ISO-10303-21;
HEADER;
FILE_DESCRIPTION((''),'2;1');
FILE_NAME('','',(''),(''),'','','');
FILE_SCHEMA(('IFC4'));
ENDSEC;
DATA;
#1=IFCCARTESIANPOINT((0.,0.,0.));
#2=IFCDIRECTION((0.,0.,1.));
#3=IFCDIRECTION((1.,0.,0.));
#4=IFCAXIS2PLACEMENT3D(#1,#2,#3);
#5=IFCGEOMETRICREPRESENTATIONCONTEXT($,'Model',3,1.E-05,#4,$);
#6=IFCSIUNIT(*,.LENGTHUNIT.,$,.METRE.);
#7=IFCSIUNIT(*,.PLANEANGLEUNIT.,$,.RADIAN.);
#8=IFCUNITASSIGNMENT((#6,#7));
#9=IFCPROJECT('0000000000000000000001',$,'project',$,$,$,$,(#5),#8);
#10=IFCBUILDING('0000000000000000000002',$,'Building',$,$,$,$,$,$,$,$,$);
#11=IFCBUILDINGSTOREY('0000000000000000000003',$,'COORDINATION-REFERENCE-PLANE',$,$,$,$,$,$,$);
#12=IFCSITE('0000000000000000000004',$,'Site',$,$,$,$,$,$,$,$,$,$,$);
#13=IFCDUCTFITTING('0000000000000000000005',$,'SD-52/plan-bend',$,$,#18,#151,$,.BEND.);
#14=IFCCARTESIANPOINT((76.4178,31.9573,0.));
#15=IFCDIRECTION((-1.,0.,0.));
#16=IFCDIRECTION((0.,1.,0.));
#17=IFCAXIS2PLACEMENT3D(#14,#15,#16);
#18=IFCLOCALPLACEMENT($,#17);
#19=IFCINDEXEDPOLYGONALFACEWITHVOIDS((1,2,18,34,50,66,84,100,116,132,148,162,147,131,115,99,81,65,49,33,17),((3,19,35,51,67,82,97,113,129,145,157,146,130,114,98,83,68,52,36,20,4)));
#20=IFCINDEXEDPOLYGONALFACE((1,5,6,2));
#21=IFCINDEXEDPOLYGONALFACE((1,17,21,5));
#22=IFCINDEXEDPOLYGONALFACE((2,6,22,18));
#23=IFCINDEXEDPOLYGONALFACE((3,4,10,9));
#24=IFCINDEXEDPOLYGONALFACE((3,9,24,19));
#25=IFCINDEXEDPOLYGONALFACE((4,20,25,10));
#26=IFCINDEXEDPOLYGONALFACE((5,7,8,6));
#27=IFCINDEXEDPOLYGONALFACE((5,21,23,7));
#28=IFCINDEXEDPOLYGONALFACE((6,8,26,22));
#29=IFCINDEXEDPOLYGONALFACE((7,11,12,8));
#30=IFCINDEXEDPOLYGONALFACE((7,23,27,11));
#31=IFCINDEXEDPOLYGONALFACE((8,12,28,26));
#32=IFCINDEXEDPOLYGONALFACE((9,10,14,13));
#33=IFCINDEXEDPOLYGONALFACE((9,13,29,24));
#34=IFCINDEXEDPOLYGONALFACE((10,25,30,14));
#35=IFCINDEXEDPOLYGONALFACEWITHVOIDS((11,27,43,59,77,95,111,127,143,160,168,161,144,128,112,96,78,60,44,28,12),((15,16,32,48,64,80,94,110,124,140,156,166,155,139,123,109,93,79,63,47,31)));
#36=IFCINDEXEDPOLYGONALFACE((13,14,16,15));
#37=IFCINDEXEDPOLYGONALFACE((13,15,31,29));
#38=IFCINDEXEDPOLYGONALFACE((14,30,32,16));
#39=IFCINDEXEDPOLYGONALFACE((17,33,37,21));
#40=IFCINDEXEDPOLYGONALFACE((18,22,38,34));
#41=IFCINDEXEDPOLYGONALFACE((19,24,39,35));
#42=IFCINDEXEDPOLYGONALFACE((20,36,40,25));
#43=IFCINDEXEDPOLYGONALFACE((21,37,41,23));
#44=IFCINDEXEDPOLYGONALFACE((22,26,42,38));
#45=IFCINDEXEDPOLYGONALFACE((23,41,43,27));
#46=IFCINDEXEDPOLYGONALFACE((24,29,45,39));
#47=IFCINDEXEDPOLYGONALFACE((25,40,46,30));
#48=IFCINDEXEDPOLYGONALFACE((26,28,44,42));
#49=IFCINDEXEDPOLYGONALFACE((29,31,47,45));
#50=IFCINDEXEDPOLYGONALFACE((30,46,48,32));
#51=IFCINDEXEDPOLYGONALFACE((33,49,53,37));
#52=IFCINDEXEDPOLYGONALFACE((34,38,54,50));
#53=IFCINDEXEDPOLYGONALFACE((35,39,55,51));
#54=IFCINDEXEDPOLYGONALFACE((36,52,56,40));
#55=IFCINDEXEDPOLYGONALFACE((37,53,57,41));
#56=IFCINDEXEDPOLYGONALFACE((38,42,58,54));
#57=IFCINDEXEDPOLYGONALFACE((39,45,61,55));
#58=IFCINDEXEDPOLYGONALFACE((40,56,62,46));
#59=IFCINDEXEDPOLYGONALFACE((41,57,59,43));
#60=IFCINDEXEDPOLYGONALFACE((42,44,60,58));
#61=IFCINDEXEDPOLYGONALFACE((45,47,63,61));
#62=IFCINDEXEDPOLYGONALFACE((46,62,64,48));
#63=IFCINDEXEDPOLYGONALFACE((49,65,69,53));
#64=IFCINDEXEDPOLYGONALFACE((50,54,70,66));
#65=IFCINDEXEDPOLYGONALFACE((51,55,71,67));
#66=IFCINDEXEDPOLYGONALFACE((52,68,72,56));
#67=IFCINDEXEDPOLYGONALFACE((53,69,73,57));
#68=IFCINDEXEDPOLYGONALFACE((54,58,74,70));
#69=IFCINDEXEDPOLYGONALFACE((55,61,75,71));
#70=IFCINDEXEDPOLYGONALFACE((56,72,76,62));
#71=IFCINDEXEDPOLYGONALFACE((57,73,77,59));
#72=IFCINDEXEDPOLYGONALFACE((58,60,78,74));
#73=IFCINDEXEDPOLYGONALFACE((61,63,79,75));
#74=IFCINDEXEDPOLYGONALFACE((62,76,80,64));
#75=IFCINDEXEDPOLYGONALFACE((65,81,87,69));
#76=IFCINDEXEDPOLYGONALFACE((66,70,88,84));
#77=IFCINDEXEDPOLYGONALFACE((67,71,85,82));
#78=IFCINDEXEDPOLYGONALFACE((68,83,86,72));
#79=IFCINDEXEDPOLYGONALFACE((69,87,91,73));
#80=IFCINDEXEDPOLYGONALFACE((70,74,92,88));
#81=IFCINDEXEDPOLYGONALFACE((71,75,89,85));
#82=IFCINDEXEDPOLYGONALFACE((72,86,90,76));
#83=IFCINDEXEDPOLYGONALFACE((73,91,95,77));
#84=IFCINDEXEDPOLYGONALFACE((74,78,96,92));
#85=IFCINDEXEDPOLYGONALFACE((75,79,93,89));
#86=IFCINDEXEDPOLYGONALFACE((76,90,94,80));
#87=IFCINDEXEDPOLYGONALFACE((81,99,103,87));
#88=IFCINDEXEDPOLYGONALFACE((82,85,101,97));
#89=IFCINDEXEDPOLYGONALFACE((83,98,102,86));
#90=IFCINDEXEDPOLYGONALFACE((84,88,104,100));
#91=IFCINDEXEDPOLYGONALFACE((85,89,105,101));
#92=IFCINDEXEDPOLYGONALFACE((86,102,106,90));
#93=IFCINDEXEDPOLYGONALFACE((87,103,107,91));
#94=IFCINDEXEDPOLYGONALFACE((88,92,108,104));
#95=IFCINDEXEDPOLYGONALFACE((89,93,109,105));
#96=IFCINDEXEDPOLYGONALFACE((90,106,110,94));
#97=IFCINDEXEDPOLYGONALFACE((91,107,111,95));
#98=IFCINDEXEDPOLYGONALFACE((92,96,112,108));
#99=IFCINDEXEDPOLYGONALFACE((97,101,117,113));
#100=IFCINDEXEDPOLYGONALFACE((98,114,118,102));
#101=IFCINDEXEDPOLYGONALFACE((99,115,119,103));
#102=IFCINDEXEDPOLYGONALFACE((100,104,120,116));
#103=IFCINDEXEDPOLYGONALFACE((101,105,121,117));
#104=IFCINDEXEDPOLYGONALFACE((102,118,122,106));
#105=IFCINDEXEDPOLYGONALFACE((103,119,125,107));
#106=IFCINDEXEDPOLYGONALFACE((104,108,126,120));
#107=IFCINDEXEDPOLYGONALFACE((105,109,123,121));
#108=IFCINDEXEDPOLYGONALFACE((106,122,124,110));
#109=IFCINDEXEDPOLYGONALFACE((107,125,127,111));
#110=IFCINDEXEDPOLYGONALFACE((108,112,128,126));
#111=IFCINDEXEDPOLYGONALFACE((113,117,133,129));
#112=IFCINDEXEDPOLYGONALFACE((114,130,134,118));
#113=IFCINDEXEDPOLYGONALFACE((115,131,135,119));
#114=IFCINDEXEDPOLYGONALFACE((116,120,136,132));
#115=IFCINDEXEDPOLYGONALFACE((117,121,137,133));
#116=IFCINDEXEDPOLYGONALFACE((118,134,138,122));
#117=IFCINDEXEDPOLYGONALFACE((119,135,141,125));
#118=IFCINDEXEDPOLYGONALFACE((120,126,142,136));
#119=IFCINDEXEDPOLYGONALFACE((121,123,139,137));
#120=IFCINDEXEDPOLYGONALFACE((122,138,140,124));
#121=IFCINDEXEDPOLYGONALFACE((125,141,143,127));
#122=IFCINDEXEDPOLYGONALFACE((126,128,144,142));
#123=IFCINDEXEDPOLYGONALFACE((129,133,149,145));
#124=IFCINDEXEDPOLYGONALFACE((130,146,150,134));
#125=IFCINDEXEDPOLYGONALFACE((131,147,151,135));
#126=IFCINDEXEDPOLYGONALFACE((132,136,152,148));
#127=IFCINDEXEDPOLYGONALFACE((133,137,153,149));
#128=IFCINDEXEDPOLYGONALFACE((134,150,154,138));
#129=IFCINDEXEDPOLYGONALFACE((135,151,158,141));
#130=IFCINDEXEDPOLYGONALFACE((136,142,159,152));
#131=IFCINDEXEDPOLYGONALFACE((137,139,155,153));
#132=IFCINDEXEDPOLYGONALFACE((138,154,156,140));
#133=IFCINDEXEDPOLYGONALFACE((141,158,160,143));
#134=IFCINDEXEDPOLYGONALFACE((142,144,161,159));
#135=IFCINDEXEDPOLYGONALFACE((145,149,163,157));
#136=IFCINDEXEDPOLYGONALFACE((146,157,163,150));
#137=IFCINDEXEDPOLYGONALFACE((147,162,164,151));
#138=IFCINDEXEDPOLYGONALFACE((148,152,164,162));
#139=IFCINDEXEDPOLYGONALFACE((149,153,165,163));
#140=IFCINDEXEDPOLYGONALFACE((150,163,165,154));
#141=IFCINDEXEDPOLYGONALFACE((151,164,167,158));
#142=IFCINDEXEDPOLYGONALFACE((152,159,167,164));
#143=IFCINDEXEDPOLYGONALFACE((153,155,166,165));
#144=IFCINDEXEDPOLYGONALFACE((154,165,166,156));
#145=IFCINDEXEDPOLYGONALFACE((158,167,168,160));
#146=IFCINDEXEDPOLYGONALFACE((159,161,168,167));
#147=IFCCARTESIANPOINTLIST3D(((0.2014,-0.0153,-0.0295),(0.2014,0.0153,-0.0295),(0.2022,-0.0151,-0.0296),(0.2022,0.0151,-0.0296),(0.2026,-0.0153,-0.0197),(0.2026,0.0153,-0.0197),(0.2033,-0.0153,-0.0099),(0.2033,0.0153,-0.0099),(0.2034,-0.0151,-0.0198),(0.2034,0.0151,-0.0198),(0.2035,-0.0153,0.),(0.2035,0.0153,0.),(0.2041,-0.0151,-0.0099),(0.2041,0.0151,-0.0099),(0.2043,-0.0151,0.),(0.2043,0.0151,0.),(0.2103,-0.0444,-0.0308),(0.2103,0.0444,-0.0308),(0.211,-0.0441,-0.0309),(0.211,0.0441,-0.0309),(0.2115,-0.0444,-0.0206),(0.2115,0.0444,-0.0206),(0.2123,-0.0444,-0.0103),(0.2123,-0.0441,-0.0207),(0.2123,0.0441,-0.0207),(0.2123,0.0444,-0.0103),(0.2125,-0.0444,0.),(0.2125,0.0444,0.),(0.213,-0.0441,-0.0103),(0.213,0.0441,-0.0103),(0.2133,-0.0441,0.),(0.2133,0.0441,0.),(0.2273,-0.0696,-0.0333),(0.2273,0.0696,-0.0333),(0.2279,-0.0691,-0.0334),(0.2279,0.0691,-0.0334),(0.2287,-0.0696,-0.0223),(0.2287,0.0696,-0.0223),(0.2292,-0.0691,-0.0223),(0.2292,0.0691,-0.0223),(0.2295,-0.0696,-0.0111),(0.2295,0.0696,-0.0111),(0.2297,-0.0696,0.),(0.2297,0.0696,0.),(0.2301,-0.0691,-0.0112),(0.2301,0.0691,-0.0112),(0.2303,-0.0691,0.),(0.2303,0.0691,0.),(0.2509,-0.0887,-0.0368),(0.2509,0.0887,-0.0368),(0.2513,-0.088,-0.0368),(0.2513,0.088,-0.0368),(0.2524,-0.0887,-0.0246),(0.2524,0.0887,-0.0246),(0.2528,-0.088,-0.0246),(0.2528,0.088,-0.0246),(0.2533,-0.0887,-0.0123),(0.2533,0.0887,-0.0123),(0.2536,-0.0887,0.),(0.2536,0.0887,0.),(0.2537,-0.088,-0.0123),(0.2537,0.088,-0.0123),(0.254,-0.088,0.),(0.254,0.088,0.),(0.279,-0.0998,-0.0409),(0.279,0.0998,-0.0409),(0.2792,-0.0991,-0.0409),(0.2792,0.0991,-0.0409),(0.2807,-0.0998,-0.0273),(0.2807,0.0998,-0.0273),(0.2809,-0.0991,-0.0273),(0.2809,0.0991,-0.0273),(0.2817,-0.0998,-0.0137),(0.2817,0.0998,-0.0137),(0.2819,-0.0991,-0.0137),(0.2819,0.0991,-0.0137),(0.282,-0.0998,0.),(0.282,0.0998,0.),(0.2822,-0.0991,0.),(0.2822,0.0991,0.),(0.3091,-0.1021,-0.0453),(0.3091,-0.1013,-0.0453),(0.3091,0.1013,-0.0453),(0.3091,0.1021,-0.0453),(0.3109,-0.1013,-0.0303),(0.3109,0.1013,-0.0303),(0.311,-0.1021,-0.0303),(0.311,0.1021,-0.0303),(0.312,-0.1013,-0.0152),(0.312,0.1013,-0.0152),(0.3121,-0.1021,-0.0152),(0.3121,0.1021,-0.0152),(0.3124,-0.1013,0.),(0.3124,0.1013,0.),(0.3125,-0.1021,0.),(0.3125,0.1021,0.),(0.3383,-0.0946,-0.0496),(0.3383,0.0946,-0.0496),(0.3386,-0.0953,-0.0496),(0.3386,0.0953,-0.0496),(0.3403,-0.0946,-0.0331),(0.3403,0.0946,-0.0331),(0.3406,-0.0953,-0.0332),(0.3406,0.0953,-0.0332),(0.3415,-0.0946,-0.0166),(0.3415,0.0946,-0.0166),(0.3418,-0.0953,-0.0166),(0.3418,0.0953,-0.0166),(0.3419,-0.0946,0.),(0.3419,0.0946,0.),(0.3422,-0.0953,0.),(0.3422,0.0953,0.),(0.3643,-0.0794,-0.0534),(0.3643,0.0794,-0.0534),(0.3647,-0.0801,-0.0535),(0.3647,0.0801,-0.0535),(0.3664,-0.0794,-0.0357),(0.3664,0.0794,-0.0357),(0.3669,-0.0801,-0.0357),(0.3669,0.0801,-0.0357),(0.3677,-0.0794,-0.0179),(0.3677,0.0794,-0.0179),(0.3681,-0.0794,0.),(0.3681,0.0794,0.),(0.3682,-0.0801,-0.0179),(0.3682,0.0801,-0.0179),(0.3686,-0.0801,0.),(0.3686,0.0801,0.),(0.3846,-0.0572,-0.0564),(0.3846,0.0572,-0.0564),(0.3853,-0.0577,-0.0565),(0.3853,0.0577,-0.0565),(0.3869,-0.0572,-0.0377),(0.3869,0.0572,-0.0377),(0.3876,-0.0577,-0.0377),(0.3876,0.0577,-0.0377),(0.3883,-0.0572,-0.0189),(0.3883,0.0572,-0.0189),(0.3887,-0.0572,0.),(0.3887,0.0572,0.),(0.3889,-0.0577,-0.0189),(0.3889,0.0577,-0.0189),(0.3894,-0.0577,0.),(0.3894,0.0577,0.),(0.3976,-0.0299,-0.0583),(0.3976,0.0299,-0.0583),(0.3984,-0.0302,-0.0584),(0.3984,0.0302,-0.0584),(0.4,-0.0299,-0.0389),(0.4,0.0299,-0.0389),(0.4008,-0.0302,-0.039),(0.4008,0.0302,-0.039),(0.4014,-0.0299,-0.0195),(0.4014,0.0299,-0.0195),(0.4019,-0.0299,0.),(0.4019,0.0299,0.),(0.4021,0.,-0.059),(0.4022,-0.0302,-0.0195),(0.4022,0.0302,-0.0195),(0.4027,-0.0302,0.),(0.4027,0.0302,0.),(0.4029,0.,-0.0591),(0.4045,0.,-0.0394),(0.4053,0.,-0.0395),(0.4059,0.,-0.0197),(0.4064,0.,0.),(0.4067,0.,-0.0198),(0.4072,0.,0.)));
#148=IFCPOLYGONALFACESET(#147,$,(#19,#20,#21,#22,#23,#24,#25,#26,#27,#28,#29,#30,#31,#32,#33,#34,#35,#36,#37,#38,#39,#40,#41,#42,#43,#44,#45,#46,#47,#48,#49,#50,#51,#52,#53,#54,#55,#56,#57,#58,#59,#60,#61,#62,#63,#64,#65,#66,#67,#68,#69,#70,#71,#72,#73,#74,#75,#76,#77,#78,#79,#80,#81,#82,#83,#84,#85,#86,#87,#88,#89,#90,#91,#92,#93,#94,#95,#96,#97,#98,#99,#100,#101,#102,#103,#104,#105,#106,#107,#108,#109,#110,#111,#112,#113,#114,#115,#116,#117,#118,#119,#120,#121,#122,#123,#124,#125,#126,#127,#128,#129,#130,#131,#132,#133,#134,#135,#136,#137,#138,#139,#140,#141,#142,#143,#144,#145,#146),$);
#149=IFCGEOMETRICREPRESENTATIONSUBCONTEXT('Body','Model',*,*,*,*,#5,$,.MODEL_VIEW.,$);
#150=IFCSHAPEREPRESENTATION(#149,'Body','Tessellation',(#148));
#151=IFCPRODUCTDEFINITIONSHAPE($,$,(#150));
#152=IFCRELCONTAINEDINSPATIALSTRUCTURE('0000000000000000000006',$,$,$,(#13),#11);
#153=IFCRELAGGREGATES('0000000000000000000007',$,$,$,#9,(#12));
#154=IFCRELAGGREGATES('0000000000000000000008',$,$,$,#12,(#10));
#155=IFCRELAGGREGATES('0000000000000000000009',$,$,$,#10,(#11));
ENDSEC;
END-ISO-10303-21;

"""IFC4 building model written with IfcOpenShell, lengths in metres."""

from ifc_helpers import new_model, entity, si_unit, frame, origin_with_axes, place, context, subcontext, project, spatial, element, save


model = new_model("IFC4")

# Units and contexts
model_context_1 = context("Model", 3, precision=1e-05, world=origin_with_axes())
body_context_1 = subcontext(model_context_1, "Body", "Model", "MODEL_VIEW")
ifc_project = project(units=[si_unit("LENGTHUNIT", "METRE"), si_unit("PLANEANGLEUNIT", "RADIAN")], contexts=[model_context_1])

# Site, building, storey
site = spatial("IfcSite", under=ifc_project, Name="Site")
building = spatial("IfcBuilding", under=site, Name="Building")
storey = spatial("IfcBuildingStorey", under=building, Name="COORDINATION-REFERENCE-PLANE")

# Duct fitting
duct_fitting_1_placement = place(None, frame((76.4178, 31.9573, 0.0), z_axis=(-1.0, 0.0, 0.0), x_axis=(0.0, 1.0, 0.0)))
element("IfcDuctFitting", 1, at=duct_fitting_1_placement, inside=storey, Name="SD-52/plan-bend", PredefinedType="BEND", context=body_context_1, shape_type="SweptSolid", body=[
    entity("IfcRevolvedAreaSolid", entity("IfcCircleHollowProfileDef", "AREA", None, entity("IfcAxis2Placement2D", entity("IfcCartesianPoint", [0.3048, 0.0])), 0.1024, 0.0008), entity("IfcAxis2Placement3D", entity("IfcCartesianPoint", [0.0, 0.0, 0.0]), entity("IfcDirection", [0.0, 0.0, 1.0]), entity("IfcDirection", [1.0, 0.0, 0.0])), entity("IfcAxis1Placement", entity("IfcCartesianPoint", [0.0, 0.0, 0.0]), entity("IfcDirection", [0.0, 1.0, 0.0])), 0.145576),
])

save(model, "model.ifc")
